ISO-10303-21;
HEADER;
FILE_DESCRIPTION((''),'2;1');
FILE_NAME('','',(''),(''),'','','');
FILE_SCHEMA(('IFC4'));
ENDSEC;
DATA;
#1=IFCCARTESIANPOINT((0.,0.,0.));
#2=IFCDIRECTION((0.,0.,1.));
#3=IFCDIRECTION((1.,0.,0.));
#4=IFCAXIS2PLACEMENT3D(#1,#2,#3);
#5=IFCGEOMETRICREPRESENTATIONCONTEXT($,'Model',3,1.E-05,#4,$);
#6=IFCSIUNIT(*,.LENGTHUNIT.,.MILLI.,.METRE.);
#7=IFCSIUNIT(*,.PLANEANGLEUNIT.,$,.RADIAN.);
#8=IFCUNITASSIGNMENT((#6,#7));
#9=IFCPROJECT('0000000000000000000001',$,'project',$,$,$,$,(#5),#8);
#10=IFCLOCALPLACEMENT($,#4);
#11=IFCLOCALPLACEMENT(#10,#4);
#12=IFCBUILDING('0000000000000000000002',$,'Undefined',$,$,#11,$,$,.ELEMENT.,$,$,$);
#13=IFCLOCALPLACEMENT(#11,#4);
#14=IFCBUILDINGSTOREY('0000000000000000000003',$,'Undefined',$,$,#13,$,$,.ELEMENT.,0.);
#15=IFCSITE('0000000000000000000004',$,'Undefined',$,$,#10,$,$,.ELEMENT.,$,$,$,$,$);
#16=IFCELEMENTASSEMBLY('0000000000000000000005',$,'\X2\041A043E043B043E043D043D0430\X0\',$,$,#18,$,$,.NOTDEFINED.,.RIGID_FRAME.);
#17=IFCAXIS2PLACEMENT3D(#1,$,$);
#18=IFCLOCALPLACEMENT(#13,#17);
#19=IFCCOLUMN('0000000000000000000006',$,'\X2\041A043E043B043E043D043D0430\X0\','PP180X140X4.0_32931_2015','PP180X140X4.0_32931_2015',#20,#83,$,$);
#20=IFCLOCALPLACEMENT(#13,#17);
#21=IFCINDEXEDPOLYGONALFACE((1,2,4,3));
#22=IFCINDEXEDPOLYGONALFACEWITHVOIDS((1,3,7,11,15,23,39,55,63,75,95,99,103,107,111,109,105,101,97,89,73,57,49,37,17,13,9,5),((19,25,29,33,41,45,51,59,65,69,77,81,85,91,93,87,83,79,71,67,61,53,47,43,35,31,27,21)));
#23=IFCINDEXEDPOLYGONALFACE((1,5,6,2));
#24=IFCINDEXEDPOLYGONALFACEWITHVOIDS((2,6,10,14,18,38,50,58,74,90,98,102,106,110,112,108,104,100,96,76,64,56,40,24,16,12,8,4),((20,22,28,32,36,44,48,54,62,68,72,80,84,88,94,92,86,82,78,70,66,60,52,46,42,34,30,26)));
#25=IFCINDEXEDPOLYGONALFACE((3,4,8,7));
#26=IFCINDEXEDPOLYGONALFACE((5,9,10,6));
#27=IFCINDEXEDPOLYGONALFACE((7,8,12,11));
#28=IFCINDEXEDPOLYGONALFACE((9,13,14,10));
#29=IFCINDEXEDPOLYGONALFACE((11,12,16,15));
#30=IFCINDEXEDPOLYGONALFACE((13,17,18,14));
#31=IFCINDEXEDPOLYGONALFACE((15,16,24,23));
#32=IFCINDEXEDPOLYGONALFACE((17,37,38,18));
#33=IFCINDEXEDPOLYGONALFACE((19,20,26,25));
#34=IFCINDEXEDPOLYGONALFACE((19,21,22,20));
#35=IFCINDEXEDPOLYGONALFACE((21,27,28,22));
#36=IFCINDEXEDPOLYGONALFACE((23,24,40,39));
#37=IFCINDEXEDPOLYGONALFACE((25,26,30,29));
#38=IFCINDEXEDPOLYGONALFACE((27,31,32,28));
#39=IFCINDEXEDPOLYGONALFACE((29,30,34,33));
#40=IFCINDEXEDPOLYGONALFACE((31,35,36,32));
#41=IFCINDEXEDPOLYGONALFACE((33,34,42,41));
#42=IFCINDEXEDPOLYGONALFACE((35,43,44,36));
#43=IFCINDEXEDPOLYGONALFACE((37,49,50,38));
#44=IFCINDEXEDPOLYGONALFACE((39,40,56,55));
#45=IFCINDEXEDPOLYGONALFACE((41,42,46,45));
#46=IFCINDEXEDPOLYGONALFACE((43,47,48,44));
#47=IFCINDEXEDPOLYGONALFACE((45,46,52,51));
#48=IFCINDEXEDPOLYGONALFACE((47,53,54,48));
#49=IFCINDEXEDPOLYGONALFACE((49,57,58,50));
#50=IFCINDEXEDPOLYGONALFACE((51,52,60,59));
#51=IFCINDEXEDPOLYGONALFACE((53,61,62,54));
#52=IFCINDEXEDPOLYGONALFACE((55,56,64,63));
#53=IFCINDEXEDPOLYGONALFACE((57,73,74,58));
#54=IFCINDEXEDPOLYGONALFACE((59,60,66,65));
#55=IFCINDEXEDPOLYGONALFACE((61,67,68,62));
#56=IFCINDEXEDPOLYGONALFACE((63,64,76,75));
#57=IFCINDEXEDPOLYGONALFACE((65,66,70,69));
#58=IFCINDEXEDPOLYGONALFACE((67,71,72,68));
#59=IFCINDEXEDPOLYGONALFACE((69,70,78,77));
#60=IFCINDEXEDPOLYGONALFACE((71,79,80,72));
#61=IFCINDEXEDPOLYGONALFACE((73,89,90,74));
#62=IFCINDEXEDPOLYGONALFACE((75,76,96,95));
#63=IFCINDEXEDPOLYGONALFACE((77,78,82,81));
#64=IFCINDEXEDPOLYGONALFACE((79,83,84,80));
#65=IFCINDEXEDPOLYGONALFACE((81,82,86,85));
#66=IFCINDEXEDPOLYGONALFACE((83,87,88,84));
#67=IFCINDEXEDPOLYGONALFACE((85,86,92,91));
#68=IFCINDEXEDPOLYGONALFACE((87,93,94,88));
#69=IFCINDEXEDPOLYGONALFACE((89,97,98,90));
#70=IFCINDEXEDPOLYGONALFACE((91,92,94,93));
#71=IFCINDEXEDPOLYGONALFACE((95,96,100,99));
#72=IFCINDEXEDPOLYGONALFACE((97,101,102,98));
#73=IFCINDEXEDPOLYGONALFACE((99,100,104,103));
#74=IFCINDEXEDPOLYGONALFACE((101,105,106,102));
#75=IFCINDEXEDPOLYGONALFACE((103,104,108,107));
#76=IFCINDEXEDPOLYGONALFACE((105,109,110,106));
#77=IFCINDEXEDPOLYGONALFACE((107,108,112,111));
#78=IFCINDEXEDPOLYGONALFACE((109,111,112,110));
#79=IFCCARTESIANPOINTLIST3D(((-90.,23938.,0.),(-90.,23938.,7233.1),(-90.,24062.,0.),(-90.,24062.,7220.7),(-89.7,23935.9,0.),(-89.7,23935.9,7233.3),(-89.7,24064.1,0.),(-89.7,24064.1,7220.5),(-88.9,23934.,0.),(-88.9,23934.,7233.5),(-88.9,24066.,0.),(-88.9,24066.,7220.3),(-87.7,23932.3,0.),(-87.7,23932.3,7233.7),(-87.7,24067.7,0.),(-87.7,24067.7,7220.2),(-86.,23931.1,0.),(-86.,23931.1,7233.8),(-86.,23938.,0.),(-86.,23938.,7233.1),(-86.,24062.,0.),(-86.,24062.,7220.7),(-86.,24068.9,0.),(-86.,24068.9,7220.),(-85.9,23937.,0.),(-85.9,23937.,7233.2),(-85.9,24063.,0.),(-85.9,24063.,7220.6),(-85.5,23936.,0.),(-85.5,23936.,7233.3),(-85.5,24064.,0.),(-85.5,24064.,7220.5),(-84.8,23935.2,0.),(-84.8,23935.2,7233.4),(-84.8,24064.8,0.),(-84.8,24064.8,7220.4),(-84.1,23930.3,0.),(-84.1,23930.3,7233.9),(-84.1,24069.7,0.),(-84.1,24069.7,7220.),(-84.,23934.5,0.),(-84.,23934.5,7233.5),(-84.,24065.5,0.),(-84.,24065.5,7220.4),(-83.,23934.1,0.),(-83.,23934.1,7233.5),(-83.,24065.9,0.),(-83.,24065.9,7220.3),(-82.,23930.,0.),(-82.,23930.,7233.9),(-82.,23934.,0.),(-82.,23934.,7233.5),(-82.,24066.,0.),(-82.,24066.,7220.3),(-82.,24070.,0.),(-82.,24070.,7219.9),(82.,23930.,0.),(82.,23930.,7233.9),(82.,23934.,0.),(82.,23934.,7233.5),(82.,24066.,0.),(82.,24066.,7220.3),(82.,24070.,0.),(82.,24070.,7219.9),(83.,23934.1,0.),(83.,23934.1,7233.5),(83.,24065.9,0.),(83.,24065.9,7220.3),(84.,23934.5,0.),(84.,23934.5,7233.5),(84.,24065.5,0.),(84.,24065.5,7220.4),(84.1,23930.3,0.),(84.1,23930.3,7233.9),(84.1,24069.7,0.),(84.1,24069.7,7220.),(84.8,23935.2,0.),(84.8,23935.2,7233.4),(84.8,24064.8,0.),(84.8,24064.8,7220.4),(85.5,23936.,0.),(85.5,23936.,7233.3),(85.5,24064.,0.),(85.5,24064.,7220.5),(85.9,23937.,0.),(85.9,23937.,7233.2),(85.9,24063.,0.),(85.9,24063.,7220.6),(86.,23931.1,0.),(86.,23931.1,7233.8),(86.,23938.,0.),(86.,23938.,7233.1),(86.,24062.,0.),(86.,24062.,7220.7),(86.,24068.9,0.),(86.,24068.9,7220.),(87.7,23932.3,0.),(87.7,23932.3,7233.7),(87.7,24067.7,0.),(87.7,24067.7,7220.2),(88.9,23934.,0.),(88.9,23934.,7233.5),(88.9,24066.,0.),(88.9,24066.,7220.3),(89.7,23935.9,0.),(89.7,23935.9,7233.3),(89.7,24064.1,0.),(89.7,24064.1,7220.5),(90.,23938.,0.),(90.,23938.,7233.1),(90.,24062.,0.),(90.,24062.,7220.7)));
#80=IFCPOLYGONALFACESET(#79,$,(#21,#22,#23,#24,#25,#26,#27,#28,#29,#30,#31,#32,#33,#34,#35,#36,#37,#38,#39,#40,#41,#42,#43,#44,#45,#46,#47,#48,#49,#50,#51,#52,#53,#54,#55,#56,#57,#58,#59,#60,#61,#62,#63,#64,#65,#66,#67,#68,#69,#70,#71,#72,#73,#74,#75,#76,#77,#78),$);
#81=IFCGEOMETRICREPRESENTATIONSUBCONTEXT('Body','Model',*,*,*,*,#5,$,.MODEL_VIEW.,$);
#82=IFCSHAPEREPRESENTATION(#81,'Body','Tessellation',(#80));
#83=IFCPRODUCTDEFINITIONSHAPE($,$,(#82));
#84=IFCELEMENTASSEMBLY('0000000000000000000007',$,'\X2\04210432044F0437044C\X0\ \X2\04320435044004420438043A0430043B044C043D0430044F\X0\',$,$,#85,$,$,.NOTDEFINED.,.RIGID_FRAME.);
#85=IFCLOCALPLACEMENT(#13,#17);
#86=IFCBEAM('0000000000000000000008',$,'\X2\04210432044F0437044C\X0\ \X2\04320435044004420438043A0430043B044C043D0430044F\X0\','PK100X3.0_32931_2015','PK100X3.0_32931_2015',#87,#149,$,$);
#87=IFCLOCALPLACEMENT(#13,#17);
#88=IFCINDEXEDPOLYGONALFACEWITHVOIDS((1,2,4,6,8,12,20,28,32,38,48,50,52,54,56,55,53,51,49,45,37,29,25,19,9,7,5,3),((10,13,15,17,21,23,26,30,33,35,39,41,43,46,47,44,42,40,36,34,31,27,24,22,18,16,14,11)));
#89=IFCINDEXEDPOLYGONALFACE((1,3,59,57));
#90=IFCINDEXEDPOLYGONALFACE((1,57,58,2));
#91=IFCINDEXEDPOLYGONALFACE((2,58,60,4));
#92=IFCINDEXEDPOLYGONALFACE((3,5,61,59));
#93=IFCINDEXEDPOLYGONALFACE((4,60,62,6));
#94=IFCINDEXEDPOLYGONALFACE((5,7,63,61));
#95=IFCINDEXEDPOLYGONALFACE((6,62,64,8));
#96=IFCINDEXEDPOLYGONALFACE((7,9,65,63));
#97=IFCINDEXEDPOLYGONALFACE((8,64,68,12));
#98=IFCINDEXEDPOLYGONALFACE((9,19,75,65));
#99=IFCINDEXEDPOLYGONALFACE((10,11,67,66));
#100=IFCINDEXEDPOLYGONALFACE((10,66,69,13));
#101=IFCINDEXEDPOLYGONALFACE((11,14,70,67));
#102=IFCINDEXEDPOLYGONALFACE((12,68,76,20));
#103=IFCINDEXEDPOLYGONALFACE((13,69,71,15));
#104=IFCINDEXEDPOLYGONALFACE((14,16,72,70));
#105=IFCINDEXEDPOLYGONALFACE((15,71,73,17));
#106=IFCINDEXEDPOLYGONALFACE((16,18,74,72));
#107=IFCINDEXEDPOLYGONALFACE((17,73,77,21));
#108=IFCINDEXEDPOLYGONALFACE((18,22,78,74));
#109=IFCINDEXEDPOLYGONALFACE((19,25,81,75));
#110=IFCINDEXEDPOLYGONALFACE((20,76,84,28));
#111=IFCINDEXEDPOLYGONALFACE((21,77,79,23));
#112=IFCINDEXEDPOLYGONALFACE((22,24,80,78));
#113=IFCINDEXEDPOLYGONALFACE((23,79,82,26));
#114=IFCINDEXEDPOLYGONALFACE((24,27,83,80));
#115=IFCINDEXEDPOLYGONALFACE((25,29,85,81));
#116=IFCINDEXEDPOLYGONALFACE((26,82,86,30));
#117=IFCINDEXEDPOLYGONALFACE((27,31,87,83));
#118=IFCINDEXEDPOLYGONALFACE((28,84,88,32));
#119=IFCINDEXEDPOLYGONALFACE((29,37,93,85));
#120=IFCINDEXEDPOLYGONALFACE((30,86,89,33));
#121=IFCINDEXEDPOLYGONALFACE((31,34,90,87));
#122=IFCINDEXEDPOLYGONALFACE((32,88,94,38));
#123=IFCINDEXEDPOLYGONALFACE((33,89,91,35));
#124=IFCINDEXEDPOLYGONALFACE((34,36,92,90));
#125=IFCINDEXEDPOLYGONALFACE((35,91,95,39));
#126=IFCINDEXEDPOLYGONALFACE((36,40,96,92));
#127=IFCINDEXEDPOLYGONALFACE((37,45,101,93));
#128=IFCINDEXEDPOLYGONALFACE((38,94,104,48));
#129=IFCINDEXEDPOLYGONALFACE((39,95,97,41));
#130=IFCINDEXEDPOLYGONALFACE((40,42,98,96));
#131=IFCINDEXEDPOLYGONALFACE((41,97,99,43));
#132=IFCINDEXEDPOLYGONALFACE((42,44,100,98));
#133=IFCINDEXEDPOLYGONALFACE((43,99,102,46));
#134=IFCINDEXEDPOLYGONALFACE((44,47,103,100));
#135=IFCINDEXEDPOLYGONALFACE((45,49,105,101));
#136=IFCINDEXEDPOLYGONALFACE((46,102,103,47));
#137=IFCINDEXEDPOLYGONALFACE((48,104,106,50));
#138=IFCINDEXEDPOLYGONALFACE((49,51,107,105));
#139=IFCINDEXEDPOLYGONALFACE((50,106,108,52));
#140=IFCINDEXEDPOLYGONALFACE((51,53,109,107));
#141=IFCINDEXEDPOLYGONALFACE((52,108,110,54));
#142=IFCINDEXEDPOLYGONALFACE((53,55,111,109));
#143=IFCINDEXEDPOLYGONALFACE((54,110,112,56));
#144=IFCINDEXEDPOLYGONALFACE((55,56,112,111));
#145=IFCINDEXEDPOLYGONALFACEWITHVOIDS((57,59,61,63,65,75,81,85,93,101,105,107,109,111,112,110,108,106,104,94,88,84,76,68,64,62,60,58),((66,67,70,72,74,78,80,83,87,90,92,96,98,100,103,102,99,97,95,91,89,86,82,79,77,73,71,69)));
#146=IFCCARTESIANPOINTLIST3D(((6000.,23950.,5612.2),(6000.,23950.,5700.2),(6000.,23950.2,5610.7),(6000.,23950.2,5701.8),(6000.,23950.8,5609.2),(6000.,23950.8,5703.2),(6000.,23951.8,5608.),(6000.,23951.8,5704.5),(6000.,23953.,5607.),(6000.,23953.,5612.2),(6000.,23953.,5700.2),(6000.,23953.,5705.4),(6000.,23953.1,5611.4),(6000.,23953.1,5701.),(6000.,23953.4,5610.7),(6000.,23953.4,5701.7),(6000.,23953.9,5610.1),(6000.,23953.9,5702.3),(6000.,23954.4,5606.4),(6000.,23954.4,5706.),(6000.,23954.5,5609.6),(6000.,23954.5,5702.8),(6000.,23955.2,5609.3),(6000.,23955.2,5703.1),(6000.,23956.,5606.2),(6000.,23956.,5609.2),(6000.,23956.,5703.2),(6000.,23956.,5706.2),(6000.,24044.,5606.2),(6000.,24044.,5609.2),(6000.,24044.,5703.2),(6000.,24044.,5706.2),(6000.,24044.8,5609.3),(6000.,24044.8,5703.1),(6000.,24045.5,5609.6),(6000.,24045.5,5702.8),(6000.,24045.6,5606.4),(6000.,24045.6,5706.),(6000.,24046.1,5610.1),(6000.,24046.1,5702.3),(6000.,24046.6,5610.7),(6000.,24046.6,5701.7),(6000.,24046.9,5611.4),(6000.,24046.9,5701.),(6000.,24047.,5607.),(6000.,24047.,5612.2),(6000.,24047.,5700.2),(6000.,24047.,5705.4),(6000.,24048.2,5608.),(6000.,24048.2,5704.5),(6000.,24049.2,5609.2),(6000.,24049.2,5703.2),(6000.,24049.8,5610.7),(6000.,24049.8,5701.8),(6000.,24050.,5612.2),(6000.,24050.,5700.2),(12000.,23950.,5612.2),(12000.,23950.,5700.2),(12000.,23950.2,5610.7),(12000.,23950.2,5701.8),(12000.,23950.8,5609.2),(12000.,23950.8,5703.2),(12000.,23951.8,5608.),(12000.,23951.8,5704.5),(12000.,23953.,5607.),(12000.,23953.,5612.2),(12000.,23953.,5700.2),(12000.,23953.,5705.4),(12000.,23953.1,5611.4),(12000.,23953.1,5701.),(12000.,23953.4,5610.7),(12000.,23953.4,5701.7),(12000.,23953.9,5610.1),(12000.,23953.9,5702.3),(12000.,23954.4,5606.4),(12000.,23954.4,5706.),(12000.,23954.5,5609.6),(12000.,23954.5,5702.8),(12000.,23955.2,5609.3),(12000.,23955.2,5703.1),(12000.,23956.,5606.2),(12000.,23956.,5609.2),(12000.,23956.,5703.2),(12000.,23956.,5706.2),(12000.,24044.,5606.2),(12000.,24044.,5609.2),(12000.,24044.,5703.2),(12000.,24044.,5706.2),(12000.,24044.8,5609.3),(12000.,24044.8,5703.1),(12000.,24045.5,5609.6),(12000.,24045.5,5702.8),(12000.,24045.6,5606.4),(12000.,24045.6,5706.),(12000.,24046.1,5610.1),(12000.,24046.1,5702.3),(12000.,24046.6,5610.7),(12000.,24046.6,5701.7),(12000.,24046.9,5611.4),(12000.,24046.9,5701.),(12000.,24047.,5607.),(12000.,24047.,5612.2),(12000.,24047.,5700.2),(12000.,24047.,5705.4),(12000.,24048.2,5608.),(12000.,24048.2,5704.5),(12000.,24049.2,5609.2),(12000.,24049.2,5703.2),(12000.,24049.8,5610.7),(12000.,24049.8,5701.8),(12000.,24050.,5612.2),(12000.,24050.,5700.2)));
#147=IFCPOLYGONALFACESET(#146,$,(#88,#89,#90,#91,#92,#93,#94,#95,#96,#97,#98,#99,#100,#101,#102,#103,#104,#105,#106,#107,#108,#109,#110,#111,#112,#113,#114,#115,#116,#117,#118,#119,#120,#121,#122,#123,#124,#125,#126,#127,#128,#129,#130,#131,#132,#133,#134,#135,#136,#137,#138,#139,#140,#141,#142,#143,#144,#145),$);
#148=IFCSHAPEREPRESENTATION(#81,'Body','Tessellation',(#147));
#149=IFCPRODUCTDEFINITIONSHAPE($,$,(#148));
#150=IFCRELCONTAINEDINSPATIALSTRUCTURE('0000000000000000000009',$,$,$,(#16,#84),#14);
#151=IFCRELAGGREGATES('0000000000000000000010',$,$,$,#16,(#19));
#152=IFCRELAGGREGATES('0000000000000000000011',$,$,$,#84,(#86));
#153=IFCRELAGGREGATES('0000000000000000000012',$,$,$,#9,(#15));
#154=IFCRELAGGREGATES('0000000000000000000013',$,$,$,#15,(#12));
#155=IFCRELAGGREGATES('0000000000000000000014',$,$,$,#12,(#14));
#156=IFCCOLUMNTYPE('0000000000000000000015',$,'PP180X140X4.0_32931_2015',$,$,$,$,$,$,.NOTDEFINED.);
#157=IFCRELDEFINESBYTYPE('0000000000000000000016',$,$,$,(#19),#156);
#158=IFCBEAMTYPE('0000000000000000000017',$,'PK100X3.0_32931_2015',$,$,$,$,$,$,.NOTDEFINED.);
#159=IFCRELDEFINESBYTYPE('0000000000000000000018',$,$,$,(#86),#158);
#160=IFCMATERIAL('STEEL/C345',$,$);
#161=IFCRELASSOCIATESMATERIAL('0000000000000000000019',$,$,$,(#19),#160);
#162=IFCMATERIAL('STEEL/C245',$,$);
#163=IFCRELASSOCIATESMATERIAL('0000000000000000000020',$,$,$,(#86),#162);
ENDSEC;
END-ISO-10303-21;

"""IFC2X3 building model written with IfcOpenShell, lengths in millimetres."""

from ifc_helpers import new_model, si_unit, frame, origin_with_axes, origin_2d_with_axis, place, context, subcontext, project, spatial, hollow_rectangle, extrude, clip, halfspace, material, type_object, element, aggregate, save


model = new_model("IFC2X3")

# Units and contexts
model_context = context("Model", 3, precision=1e-05, world=origin_with_axes())
body_context = subcontext(model_context, "Body", "Model", "MODEL_VIEW")
ifc_project = project(units=[si_unit("LENGTHUNIT", "METRE", prefix="MILLI"), si_unit("PLANEANGLEUNIT", "RADIAN")], contexts=[model_context])

# Site, building, storey
site_placement = place(None, origin_with_axes())
site = spatial("IfcSite", under=ifc_project, at=site_placement, Name="Undefined", CompositionType="ELEMENT")
building_placement = place(site_placement, origin_with_axes())
building = spatial("IfcBuilding", under=site, at=building_placement, Name="Undefined", CompositionType="ELEMENT")
storey_placement = place(building_placement, origin_with_axes())
storey = spatial("IfcBuildingStorey", under=building, at=storey_placement, Name="Undefined", CompositionType="ELEMENT", Elevation=0.0)

# Element assembly, column
assembly_1_placement = place(storey_placement, origin_with_axes())
assembly_1 = element("IfcElementAssembly", 1, at=assembly_1_placement, inside=storey, Name="Колонна", AssemblyPlace="NOTDEFINED", PredefinedType="RIGID_FRAME")
ifc_material_1 = material(Name="STEEL/C345")
column_type = type_object("IfcColumnType", Name="PP180X140X4.0_32931_2015", PredefinedType="NOTDEFINED")
column_placement = place(assembly_1_placement, frame((0.0, 24000.0, 0.0), z_axis=(0.0, 0.0, 1.0), x_axis=(-1.0, 0.0, 0.0)))
column = element("IfcColumn", 2, at=column_placement, type_object=column_type, material=ifc_material_1, Name="Колонна", Description="PP180X140X4.0_32931_2015", ObjectType="PP180X140X4.0_32931_2015", context=body_context, shape_type="Clipping", body=[
    clip(extrude(hollow_rectangle(XDim=140.0, YDim=180.0, WallThickness=4.0, InnerFilletRadius=4.0, OuterFilletRadius=8.0, at=origin_2d_with_axis()), frame((0.0, 0.0, 7234.0), z_axis=(0.0, 0.0, -1.0), x_axis=(0.0, 1.0, 0.0)), (0.0, 0.0, 1.0), 7234.0), halfspace(frame((0.0, 142.2, 7241.2), z_axis=(0.0, -0.099504, 0.995037), x_axis=(-1.0, 0.0, 0.0)), False)),
])
aggregate(assembly_1, [column])

# Element assembly, beam
ifc_material_2 = material(Name="STEEL/C245")
beam_type_1 = type_object("IfcBeamType", Name="PK100X3.0_32931_2015", PredefinedType="NOTDEFINED")
assembly_2_placement = place(storey_placement, origin_with_axes())
assembly_2 = element("IfcElementAssembly", 3, at=assembly_2_placement, inside=storey, Name="Связь вертикальная", AssemblyPlace="NOTDEFINED", PredefinedType="RIGID_FRAME")
beam_1_placement = place(assembly_2_placement, frame((6000.0, 24000.0, 5656.2), z_axis=(0.0, 0.0, 1.0), x_axis=(1.0, 0.0, 0.0)))
beam_1 = element("IfcBeam", 4, at=beam_1_placement, type_object=beam_type_1, material=ifc_material_2, Name="Связь вертикальная", Description="PK100X3.0_32931_2015", ObjectType="PK100X3.0_32931_2015", context=body_context, shape_type="SweptSolid", body=[
    extrude(hollow_rectangle(XDim=100.0, YDim=100.0, WallThickness=3.0, InnerFilletRadius=3.0, OuterFilletRadius=6.0, at=origin_2d_with_axis()), frame((6000.0, 0.0, 0.0), z_axis=(-1.0, 0.0, 0.0), x_axis=(0.0, -1.0, 0.0)), (0.0, 0.0, 1.0), 6000.0),
])
aggregate(assembly_2, [beam_1])

save(model, "model.ifc")
